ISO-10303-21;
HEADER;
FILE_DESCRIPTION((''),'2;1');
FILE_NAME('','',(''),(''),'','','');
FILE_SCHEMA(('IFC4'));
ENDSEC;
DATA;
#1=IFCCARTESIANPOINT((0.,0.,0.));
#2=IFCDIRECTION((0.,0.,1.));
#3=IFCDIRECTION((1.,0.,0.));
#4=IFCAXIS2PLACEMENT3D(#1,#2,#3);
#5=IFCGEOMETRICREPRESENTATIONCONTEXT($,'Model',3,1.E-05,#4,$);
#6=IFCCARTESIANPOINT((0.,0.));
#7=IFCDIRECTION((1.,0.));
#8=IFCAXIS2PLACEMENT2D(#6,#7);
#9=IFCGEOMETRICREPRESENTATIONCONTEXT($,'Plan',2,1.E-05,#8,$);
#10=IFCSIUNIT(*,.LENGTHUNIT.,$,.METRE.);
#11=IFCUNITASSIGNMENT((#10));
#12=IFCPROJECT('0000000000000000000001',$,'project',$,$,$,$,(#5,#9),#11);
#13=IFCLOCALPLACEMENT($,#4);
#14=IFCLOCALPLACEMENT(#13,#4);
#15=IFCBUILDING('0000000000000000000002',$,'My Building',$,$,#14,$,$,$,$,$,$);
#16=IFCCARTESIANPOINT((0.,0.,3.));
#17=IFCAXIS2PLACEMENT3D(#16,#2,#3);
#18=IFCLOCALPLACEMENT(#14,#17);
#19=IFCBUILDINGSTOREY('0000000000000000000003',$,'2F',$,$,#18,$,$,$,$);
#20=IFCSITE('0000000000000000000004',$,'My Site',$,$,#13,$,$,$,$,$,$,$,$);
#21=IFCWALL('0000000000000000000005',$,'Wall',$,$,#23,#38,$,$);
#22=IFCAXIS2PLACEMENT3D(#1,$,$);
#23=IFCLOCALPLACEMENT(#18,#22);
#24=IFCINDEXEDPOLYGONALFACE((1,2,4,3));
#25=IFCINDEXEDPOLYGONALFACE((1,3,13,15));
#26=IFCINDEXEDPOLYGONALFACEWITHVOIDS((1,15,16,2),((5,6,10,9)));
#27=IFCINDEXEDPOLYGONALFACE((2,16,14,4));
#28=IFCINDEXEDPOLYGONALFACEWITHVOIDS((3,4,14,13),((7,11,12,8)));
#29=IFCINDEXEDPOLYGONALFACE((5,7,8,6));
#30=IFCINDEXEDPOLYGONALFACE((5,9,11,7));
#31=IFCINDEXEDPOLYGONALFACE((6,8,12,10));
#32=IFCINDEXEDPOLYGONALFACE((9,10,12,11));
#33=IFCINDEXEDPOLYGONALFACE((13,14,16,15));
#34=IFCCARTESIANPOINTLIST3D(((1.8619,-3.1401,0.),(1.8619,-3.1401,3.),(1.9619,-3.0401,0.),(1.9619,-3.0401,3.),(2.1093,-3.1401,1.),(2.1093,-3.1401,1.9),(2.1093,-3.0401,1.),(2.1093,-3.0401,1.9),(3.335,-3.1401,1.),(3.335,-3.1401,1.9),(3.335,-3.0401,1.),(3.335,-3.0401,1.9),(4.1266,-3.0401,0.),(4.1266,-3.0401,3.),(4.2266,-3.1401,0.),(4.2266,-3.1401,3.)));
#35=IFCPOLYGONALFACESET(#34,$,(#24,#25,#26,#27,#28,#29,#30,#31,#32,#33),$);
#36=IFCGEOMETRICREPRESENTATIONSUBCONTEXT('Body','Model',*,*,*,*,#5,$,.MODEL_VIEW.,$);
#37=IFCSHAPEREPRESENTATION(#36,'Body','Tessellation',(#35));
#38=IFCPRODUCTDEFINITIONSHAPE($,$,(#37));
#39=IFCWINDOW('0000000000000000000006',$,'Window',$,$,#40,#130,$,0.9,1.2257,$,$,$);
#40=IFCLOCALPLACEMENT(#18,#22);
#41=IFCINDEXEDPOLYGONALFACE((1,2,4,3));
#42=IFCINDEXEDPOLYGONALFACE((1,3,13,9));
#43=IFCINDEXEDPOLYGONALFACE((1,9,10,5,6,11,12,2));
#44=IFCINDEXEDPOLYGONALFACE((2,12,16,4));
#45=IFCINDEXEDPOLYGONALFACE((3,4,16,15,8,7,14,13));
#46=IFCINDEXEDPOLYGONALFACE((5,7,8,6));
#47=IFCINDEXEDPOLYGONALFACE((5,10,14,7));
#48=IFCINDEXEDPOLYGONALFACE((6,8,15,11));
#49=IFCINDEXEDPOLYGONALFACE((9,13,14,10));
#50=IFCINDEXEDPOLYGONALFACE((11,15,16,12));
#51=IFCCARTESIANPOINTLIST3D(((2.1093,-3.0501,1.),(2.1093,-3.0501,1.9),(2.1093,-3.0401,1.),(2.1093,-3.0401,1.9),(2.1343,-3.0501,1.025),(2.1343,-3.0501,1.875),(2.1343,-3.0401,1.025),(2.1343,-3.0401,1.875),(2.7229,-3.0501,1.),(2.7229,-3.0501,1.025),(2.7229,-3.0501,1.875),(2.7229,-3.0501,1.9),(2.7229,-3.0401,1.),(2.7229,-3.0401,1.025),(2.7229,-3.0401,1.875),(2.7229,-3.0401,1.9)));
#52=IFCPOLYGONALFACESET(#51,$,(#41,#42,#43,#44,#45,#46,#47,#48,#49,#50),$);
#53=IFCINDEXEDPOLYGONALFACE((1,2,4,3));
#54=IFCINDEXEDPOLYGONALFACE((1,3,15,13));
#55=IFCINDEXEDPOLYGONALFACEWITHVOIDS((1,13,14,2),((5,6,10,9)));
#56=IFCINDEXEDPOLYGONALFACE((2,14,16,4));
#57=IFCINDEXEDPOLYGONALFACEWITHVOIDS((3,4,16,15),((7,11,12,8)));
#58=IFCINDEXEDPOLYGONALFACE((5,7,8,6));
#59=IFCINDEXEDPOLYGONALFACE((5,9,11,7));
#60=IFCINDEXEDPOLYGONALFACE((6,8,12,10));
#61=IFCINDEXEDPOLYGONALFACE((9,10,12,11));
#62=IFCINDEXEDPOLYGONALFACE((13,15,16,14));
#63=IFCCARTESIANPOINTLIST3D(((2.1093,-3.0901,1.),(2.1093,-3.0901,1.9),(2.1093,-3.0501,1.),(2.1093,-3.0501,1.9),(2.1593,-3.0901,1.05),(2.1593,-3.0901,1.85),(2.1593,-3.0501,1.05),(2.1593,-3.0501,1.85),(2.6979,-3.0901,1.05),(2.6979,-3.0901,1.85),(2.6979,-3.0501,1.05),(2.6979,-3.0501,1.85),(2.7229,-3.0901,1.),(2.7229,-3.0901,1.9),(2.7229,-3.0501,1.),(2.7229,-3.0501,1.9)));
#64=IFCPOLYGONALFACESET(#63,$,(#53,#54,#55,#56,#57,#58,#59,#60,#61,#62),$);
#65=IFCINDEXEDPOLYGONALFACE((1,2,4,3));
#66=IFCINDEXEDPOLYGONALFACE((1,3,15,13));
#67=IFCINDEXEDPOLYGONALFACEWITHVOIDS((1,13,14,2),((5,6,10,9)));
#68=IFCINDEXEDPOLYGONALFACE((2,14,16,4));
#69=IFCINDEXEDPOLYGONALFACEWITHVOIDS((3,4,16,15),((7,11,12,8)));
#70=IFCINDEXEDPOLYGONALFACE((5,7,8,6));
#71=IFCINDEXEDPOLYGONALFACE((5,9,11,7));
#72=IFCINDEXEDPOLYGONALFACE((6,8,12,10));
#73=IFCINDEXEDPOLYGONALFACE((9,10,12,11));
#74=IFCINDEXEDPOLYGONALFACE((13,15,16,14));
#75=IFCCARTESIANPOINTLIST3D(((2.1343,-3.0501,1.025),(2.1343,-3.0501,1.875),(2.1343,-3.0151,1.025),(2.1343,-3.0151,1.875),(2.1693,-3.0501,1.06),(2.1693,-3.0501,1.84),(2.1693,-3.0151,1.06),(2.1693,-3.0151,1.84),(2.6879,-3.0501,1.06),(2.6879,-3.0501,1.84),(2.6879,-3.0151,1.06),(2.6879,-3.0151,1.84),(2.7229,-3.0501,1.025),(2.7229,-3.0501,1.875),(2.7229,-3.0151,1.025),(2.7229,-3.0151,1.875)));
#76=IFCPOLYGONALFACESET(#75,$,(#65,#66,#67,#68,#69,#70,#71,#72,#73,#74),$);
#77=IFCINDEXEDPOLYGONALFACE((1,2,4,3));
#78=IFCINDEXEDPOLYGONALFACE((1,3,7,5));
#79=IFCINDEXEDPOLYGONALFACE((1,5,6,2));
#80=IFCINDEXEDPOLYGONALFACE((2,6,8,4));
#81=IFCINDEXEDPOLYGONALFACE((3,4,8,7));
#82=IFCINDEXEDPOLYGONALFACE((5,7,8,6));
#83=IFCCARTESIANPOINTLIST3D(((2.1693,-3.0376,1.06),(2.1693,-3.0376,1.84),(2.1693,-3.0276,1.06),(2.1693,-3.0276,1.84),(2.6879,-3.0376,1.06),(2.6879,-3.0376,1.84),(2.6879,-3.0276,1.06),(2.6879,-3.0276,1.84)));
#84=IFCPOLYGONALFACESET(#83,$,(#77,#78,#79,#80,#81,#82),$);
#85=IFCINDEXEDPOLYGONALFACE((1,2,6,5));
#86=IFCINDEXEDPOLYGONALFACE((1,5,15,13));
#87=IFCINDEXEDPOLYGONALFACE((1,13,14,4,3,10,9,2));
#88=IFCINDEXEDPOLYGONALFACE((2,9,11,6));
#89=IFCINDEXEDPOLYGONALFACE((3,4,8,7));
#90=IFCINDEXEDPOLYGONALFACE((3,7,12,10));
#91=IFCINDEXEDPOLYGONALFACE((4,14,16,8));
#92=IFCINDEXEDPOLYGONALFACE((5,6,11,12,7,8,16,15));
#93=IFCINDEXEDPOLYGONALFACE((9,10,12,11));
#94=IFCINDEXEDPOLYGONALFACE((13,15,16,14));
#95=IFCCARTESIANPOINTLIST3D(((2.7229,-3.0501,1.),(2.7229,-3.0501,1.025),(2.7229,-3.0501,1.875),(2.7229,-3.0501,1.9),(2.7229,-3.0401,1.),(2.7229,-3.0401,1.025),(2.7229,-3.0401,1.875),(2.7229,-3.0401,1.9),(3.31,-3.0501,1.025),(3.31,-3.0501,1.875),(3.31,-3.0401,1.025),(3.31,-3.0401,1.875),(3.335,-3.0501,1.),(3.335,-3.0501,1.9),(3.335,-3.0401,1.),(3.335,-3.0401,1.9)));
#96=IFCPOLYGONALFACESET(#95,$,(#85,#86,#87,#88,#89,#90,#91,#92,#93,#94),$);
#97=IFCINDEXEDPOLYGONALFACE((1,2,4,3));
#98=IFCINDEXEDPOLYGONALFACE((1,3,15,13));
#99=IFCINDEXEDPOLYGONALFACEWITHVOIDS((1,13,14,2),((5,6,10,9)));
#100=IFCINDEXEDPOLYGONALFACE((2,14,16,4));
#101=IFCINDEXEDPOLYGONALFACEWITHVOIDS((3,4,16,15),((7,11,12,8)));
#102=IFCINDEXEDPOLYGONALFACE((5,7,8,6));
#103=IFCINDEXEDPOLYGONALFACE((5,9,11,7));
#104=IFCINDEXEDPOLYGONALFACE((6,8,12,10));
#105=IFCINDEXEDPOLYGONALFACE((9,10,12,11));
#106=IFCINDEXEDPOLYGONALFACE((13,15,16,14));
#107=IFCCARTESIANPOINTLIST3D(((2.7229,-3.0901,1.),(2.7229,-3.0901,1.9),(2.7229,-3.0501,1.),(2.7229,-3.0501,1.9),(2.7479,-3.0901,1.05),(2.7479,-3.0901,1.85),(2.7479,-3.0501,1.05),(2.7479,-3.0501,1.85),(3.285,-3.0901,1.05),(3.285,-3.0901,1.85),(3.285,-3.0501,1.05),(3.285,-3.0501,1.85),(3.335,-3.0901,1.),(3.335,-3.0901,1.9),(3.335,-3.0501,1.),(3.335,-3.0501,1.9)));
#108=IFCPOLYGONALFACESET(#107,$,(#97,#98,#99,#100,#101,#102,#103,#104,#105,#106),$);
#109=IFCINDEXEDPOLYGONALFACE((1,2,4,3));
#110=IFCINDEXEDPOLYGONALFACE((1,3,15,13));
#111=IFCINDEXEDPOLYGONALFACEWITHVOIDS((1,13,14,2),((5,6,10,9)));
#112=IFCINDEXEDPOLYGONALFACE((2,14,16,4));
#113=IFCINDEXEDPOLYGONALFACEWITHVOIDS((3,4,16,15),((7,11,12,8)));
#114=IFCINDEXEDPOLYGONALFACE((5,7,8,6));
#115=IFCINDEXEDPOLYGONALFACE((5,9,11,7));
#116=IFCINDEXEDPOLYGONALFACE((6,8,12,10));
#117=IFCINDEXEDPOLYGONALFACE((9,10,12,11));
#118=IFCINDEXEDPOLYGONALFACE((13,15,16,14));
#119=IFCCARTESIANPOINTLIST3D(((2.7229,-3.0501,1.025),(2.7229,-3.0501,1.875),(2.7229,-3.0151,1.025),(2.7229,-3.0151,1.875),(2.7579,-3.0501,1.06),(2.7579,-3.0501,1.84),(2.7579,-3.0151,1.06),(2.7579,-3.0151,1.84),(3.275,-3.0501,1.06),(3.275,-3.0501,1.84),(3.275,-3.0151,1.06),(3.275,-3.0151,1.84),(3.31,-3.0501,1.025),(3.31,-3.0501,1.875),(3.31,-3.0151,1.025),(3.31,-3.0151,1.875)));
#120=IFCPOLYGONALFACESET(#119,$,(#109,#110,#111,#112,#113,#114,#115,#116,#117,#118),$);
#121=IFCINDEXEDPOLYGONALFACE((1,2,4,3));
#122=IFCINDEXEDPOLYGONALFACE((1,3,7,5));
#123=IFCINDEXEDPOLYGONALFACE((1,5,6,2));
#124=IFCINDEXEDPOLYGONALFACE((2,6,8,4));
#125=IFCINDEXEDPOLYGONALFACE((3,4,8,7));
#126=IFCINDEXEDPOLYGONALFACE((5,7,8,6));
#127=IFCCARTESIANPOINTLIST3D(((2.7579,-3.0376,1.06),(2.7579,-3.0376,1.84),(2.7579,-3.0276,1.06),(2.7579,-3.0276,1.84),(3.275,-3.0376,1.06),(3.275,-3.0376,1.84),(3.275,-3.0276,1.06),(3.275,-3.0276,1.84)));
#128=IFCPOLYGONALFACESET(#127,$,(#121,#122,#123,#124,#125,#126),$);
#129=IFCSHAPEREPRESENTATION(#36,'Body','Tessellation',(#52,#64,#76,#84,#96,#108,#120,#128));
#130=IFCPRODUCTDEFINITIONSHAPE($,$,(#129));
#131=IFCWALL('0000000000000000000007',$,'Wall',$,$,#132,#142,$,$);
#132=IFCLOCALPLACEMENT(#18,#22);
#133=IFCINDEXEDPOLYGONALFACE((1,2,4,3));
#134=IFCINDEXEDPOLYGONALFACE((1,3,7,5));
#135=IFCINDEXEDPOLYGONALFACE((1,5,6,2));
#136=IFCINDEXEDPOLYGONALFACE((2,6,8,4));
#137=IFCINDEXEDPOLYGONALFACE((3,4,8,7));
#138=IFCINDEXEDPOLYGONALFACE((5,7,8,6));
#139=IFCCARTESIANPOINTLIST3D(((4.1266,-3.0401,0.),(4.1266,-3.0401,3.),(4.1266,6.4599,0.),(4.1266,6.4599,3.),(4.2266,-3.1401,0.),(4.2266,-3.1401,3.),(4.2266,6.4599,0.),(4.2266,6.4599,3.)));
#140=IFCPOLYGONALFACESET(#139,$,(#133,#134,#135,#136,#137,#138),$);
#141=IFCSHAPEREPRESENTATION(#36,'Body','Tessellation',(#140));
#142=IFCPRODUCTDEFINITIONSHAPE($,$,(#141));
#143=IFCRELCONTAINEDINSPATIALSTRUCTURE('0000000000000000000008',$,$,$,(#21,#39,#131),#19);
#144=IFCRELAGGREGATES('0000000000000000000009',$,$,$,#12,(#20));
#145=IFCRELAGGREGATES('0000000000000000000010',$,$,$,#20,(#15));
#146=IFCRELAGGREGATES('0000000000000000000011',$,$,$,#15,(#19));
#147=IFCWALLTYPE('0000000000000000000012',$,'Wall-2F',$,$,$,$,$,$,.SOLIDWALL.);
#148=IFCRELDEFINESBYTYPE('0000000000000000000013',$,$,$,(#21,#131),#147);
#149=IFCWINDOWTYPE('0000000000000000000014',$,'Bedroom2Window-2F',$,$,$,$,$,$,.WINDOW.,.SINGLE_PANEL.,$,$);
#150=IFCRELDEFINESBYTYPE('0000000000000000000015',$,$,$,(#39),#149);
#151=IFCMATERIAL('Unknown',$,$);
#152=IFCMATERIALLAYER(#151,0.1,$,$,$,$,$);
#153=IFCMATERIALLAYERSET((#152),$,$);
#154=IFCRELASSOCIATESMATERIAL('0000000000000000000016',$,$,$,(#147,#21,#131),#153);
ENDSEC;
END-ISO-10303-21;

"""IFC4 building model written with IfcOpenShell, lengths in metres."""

from ifc_helpers import new_model, entity, si_unit, frame, origin_with_axes, origin_2d_with_axis, place, context, subcontext, project, spatial, line, indexed_curve, outline, extrude, shape, source, transform, mapped, material, layer, layer_set, layer_usage, type_object, type_shapes, element, fill, save


model = new_model("IFC4")

# Units and contexts
model_context = context("Model", 3, precision=1e-05, world=origin_with_axes())
plan_context = context("Plan", 2, precision=1e-05, world=origin_2d_with_axis())
body_context_1 = subcontext(model_context, "Body", "Model", "MODEL_VIEW")
body_context_2 = subcontext(plan_context, "Body", "Plan", "PLAN_VIEW")
ifc_project = project(units=[si_unit("LENGTHUNIT", "METRE")], contexts=[model_context, plan_context])

# Site, building, storey
site_placement = place(None, origin_with_axes())
site = spatial("IfcSite", under=ifc_project, at=site_placement, Name="My Site")
building_placement = place(site_placement, origin_with_axes())
building = spatial("IfcBuilding", under=site, at=building_placement, Name="My Building")
storey_placement = place(building_placement, frame((0.0, 0.0, 3.0), z_axis=(0.0, 0.0, 1.0), x_axis=(1.0, 0.0, 0.0)))
storey = spatial("IfcBuildingStorey", under=building, at=storey_placement, Name="2F")

# Shared definitions
ifc_material = material(Name="Unknown")

# Shared definitions
ifc_layer_1 = layer(ifc_material, 0.1)
ifc_layer_set_1 = layer_set([ifc_layer_1])
wall_type_1 = type_object("IfcWallType", Name="Wall-2F", PredefinedType="SOLIDWALL", material=ifc_layer_set_1)

# Wall, opening, window
ifc_layer_usage_1 = layer_usage(ifc_layer_set_1, "AXIS2", "POSITIVE", 0.0)
wall_1_placement = place(storey_placement, frame((1.8619, -3.1401, 0.0), z_axis=(0.0, 0.0, 1.0), x_axis=(1.0, 0.0, 0.0)))
wall_1 = element("IfcWall", 1, at=wall_1_placement, inside=storey, type_object=wall_type_1, material=ifc_layer_usage_1, Name="Wall", context=body_context_1, shape_type="SweptSolid", body=[
    extrude(outline(indexed_curve([(0.0, 0.0), (0.1, 0.1), (2.2647, 0.1), (2.3647, 0.0)], segments=[line(1, 2, 3, 4, 1)])), origin_with_axes(), (0.0, 0.0, 1.0), 3.0),
])
shared_shape_1 = source(origin_with_axes(), body_context_1, "Body", "SweptSolid", [
    extrude(outline(indexed_curve([(0.0, 0.0), (1.2257, 0.0), (1.2257, 0.9), (0.0, 0.9)], segments=[line(1, 2, 3, 4, 1)])), frame((0.0, -0.6, 0.0), z_axis=(0.0, -1.0, 0.0), x_axis=(1.0, 0.0, 0.0)), (0.0, 0.0, -1.0), 1.2),
])
opening_1_placement = place(wall_1_placement, frame((0.2474, 0.0, 1.0), z_axis=(0.0, 0.0, 1.0), x_axis=(1.0, 0.0, 0.0)))
opening_1 = element("IfcOpeningElement", 2, at=opening_1_placement, cuts=wall_1, PredefinedType="OPENING", context=body_context_1, shape_type="MappedRepresentation", body=[
    mapped(shared_shape_1, transform((0.0, 0.0, 0.0), x_axis=(1.0, 0.0, 0.0), y_axis=(0.0, 1.0, 0.0), z_axis=(0.0, 0.0, 1.0), scale=1.0)),
])
window_type_1 = type_object("IfcWindowType", Name="Bedroom2Window-2F", PartitioningType="SINGLE_PANEL", PredefinedType="WINDOW")
shared_shape_2 = source(origin_with_axes(), body_context_1, "Body", "SweptSolid", [
    extrude(outline(indexed_curve([(0.6136, 0.0), (0.0, 0.0), (0.0, 0.9), (0.6136, 0.9), (0.6136, 0.875), (0.025, 0.875), (0.025, 0.025), (0.6136, 0.025)], segments=[line(1, 2, 3, 4, 5, 6, 7, 8, 1)])), frame((0.0, 0.09, 0.0), z_axis=(0.0, -1.0, 0.0), x_axis=(1.0, 0.0, 0.0)), (0.0, 0.0, -1.0), 0.01),
    extrude(outline(indexed_curve([(0.0, 0.0), (0.6136, 0.0), (0.6136, 0.9), (0.0, 0.9)], segments=[line(1, 2, 3, 4, 1)]), holes=[indexed_curve([(0.05, 0.05), (0.5886, 0.05), (0.5886, 0.85), (0.05, 0.85)], segments=[line(1, 2, 3, 4, 1)])]), frame((0.0, 0.05, 0.0), z_axis=(0.0, -1.0, 0.0), x_axis=(1.0, 0.0, 0.0)), (0.0, 0.0, -1.0), 0.04),
    extrude(outline(indexed_curve([(0.0, 0.0), (0.5886, 0.0), (0.5886, 0.85), (0.0, 0.85)], segments=[line(1, 2, 3, 4, 1)]), holes=[indexed_curve([(0.035, 0.035), (0.5536, 0.035), (0.5536, 0.815), (0.035, 0.815)], segments=[line(1, 2, 3, 4, 1)])]), frame((0.025, 0.09, 0.025), z_axis=(0.0, -1.0, 0.0), x_axis=(1.0, 0.0, 0.0)), (0.0, 0.0, -1.0), 0.035),
    extrude(outline(indexed_curve([(0.035, 0.035), (0.5536, 0.035), (0.5536, 0.815), (0.035, 0.815)], segments=[line(1, 2, 3, 4, 1)])), frame((0.025, 0.1025, 0.025), z_axis=(0.0, -1.0, 0.0), x_axis=(1.0, 0.0, 0.0)), (0.0, 0.0, -1.0), 0.01),
    extrude(outline(indexed_curve([(0.0, 0.9), (0.6121, 0.9), (0.6121, 0.0), (0.0, 0.0), (0.0, 0.025), (0.5871, 0.025), (0.5871, 0.875), (0.0, 0.875)], segments=[line(1, 2, 3, 4, 5, 6, 7, 8, 1)])), frame((0.6136, 0.09, 0.0), z_axis=(0.0, -1.0, 0.0), x_axis=(1.0, 0.0, 0.0)), (0.0, 0.0, -1.0), 0.01),
    extrude(outline(indexed_curve([(0.0, 0.0), (0.6121, 0.0), (0.6121, 0.9), (0.0, 0.9)], segments=[line(1, 2, 3, 4, 1)]), holes=[indexed_curve([(0.025, 0.05), (0.5621, 0.05), (0.5621, 0.85), (0.025, 0.85)], segments=[line(1, 2, 3, 4, 1)])]), frame((0.6136, 0.05, 0.0), z_axis=(0.0, -1.0, 0.0), x_axis=(1.0, 0.0, 0.0)), (0.0, 0.0, -1.0), 0.04),
    extrude(outline(indexed_curve([(0.0, 0.0), (0.5871, 0.0), (0.5871, 0.85), (0.0, 0.85)], segments=[line(1, 2, 3, 4, 1)]), holes=[indexed_curve([(0.035, 0.035), (0.5521, 0.035), (0.5521, 0.815), (0.035, 0.815)], segments=[line(1, 2, 3, 4, 1)])]), frame((0.6136, 0.09, 0.025), z_axis=(0.0, -1.0, 0.0), x_axis=(1.0, 0.0, 0.0)), (0.0, 0.0, -1.0), 0.035),
    extrude(outline(indexed_curve([(0.035, 0.035), (0.5521, 0.035), (0.5521, 0.815), (0.035, 0.815)], segments=[line(1, 2, 3, 4, 1)])), frame((0.6136, 0.1025, 0.025), z_axis=(0.0, -1.0, 0.0), x_axis=(1.0, 0.0, 0.0)), (0.0, 0.0, -1.0), 0.01),
])
shared_shape_3 = source(origin_with_axes(), body_context_2, "Body", "Curve2D", [
    entity("IfcIndexedPolyCurve", entity("IfcCartesianPointList2D", [[0.05, 0.05], [0.5886, 0.05]])),
    entity("IfcIndexedPolyCurve", entity("IfcCartesianPointList2D", [[0.0, 0.1], [0.025, 0.1], [0.025, 0.09], [0.05, 0.09], [0.05, 0.05], [0.0, 0.05]]), [entity("IfcLineIndex", [1, 2, 3, 4, 5, 6, 1])]),
    entity("IfcIndexedPolyCurve", entity("IfcCartesianPointList2D", [[0.6136, 0.1], [0.6136, 0.1], [0.6136, 0.09], [0.5886, 0.09], [0.5886, 0.05], [0.6136, 0.05]])),
    entity("IfcIndexedPolyCurve", entity("IfcCartesianPointList2D", [[0.025, 0.09], [0.06, 0.09], [0.06, 0.125], [0.025, 0.125]]), [entity("IfcLineIndex", [1, 2, 3, 4, 1])]),
    entity("IfcIndexedPolyCurve", entity("IfcCartesianPointList2D", [[0.6136, 0.09], [0.5786, 0.09], [0.5786, 0.125], [0.6136, 0.125]]), [entity("IfcLineIndex", [1, 2, 3, 4, 1])]),
    entity("IfcIndexedPolyCurve", entity("IfcCartesianPointList2D", [[0.06, 0.09], [0.5786, 0.09]])),
    entity("IfcIndexedPolyCurve", entity("IfcCartesianPointList2D", [[0.06, 0.125], [0.5786, 0.125]])),
    entity("IfcIndexedPolyCurve", entity("IfcCartesianPointList2D", [[0.06, 0.1075], [0.5786, 0.1075]])),
    entity("IfcIndexedPolyCurve", entity("IfcCartesianPointList2D", [[0.6386, 0.05], [1.1757, 0.05]])),
    entity("IfcIndexedPolyCurve", entity("IfcCartesianPointList2D", [[0.6136, 0.1], [0.6136, 0.1], [0.6136, 0.09], [0.6386, 0.09], [0.6386, 0.05], [0.6136, 0.05]])),
    entity("IfcIndexedPolyCurve", entity("IfcCartesianPointList2D", [[1.2257, 0.1], [1.2007, 0.1], [1.2007, 0.09], [1.1757, 0.09], [1.1757, 0.05], [1.2257, 0.05]]), [entity("IfcLineIndex", [1, 2, 3, 4, 5, 6, 1])]),
    entity("IfcIndexedPolyCurve", entity("IfcCartesianPointList2D", [[0.6136, 0.09], [0.6486, 0.09], [0.6486, 0.125], [0.6136, 0.125]]), [entity("IfcLineIndex", [1, 2, 3, 4, 1])]),
    entity("IfcIndexedPolyCurve", entity("IfcCartesianPointList2D", [[1.2007, 0.09], [1.1657, 0.09], [1.1657, 0.125], [1.2007, 0.125]]), [entity("IfcLineIndex", [1, 2, 3, 4, 1])]),
    entity("IfcIndexedPolyCurve", entity("IfcCartesianPointList2D", [[0.6486, 0.09], [1.1657, 0.09]])),
    entity("IfcIndexedPolyCurve", entity("IfcCartesianPointList2D", [[0.6486, 0.125], [1.1657, 0.125]])),
    entity("IfcIndexedPolyCurve", entity("IfcCartesianPointList2D", [[0.6486, 0.1075], [1.1657, 0.1075]])),
])
type_shapes(window_type_1, [shared_shape_2, shared_shape_3])
window_1_placement = place(opening_1_placement, origin_with_axes())
window_1 = element("IfcWindow", 3, at=window_1_placement, inside=storey, type_object=window_type_1, Name="Window", OverallHeight=0.9, OverallWidth=1.2257, shapes=[
    shape(body_context_1, "Body", "MappedRepresentation", [mapped(shared_shape_2, transform((0.0, 0.0, 0.0), x_axis=(1.0, 0.0, 0.0), y_axis=(0.0, 1.0, 0.0), z_axis=(0.0, 0.0, 1.0), scale=1.0))]),
    shape(body_context_2, "Body", "MappedRepresentation", [mapped(shared_shape_3, transform((0.0, 0.0, 0.0), x_axis=(1.0, 0.0, 0.0), y_axis=(0.0, 1.0, 0.0), z_axis=(0.0, 0.0, 1.0), scale=1.0))]),
])
fill(opening_1, window_1)

# Wall
ifc_layer_usage_2 = layer_usage(ifc_layer_set_1, "AXIS2", "POSITIVE", 0.0)
wall_2_placement = place(storey_placement, frame((4.2266, -3.1401, 0.0), z_axis=(0.0, 0.0, 1.0), x_axis=(0.0, 1.0, 0.0)))
element("IfcWall", 4, at=wall_2_placement, inside=storey, type_object=wall_type_1, material=ifc_layer_usage_2, Name="Wall", context=body_context_1, shape_type="SweptSolid", body=[
    extrude(outline(indexed_curve([(0.0, 0.0), (0.1, 0.1), (9.6, 0.1), (9.6, 0.0)], segments=[line(1, 2, 3, 4, 1)])), origin_with_axes(), (0.0, 0.0, 1.0), 3.0),
])

save(model, "model.ifc")
